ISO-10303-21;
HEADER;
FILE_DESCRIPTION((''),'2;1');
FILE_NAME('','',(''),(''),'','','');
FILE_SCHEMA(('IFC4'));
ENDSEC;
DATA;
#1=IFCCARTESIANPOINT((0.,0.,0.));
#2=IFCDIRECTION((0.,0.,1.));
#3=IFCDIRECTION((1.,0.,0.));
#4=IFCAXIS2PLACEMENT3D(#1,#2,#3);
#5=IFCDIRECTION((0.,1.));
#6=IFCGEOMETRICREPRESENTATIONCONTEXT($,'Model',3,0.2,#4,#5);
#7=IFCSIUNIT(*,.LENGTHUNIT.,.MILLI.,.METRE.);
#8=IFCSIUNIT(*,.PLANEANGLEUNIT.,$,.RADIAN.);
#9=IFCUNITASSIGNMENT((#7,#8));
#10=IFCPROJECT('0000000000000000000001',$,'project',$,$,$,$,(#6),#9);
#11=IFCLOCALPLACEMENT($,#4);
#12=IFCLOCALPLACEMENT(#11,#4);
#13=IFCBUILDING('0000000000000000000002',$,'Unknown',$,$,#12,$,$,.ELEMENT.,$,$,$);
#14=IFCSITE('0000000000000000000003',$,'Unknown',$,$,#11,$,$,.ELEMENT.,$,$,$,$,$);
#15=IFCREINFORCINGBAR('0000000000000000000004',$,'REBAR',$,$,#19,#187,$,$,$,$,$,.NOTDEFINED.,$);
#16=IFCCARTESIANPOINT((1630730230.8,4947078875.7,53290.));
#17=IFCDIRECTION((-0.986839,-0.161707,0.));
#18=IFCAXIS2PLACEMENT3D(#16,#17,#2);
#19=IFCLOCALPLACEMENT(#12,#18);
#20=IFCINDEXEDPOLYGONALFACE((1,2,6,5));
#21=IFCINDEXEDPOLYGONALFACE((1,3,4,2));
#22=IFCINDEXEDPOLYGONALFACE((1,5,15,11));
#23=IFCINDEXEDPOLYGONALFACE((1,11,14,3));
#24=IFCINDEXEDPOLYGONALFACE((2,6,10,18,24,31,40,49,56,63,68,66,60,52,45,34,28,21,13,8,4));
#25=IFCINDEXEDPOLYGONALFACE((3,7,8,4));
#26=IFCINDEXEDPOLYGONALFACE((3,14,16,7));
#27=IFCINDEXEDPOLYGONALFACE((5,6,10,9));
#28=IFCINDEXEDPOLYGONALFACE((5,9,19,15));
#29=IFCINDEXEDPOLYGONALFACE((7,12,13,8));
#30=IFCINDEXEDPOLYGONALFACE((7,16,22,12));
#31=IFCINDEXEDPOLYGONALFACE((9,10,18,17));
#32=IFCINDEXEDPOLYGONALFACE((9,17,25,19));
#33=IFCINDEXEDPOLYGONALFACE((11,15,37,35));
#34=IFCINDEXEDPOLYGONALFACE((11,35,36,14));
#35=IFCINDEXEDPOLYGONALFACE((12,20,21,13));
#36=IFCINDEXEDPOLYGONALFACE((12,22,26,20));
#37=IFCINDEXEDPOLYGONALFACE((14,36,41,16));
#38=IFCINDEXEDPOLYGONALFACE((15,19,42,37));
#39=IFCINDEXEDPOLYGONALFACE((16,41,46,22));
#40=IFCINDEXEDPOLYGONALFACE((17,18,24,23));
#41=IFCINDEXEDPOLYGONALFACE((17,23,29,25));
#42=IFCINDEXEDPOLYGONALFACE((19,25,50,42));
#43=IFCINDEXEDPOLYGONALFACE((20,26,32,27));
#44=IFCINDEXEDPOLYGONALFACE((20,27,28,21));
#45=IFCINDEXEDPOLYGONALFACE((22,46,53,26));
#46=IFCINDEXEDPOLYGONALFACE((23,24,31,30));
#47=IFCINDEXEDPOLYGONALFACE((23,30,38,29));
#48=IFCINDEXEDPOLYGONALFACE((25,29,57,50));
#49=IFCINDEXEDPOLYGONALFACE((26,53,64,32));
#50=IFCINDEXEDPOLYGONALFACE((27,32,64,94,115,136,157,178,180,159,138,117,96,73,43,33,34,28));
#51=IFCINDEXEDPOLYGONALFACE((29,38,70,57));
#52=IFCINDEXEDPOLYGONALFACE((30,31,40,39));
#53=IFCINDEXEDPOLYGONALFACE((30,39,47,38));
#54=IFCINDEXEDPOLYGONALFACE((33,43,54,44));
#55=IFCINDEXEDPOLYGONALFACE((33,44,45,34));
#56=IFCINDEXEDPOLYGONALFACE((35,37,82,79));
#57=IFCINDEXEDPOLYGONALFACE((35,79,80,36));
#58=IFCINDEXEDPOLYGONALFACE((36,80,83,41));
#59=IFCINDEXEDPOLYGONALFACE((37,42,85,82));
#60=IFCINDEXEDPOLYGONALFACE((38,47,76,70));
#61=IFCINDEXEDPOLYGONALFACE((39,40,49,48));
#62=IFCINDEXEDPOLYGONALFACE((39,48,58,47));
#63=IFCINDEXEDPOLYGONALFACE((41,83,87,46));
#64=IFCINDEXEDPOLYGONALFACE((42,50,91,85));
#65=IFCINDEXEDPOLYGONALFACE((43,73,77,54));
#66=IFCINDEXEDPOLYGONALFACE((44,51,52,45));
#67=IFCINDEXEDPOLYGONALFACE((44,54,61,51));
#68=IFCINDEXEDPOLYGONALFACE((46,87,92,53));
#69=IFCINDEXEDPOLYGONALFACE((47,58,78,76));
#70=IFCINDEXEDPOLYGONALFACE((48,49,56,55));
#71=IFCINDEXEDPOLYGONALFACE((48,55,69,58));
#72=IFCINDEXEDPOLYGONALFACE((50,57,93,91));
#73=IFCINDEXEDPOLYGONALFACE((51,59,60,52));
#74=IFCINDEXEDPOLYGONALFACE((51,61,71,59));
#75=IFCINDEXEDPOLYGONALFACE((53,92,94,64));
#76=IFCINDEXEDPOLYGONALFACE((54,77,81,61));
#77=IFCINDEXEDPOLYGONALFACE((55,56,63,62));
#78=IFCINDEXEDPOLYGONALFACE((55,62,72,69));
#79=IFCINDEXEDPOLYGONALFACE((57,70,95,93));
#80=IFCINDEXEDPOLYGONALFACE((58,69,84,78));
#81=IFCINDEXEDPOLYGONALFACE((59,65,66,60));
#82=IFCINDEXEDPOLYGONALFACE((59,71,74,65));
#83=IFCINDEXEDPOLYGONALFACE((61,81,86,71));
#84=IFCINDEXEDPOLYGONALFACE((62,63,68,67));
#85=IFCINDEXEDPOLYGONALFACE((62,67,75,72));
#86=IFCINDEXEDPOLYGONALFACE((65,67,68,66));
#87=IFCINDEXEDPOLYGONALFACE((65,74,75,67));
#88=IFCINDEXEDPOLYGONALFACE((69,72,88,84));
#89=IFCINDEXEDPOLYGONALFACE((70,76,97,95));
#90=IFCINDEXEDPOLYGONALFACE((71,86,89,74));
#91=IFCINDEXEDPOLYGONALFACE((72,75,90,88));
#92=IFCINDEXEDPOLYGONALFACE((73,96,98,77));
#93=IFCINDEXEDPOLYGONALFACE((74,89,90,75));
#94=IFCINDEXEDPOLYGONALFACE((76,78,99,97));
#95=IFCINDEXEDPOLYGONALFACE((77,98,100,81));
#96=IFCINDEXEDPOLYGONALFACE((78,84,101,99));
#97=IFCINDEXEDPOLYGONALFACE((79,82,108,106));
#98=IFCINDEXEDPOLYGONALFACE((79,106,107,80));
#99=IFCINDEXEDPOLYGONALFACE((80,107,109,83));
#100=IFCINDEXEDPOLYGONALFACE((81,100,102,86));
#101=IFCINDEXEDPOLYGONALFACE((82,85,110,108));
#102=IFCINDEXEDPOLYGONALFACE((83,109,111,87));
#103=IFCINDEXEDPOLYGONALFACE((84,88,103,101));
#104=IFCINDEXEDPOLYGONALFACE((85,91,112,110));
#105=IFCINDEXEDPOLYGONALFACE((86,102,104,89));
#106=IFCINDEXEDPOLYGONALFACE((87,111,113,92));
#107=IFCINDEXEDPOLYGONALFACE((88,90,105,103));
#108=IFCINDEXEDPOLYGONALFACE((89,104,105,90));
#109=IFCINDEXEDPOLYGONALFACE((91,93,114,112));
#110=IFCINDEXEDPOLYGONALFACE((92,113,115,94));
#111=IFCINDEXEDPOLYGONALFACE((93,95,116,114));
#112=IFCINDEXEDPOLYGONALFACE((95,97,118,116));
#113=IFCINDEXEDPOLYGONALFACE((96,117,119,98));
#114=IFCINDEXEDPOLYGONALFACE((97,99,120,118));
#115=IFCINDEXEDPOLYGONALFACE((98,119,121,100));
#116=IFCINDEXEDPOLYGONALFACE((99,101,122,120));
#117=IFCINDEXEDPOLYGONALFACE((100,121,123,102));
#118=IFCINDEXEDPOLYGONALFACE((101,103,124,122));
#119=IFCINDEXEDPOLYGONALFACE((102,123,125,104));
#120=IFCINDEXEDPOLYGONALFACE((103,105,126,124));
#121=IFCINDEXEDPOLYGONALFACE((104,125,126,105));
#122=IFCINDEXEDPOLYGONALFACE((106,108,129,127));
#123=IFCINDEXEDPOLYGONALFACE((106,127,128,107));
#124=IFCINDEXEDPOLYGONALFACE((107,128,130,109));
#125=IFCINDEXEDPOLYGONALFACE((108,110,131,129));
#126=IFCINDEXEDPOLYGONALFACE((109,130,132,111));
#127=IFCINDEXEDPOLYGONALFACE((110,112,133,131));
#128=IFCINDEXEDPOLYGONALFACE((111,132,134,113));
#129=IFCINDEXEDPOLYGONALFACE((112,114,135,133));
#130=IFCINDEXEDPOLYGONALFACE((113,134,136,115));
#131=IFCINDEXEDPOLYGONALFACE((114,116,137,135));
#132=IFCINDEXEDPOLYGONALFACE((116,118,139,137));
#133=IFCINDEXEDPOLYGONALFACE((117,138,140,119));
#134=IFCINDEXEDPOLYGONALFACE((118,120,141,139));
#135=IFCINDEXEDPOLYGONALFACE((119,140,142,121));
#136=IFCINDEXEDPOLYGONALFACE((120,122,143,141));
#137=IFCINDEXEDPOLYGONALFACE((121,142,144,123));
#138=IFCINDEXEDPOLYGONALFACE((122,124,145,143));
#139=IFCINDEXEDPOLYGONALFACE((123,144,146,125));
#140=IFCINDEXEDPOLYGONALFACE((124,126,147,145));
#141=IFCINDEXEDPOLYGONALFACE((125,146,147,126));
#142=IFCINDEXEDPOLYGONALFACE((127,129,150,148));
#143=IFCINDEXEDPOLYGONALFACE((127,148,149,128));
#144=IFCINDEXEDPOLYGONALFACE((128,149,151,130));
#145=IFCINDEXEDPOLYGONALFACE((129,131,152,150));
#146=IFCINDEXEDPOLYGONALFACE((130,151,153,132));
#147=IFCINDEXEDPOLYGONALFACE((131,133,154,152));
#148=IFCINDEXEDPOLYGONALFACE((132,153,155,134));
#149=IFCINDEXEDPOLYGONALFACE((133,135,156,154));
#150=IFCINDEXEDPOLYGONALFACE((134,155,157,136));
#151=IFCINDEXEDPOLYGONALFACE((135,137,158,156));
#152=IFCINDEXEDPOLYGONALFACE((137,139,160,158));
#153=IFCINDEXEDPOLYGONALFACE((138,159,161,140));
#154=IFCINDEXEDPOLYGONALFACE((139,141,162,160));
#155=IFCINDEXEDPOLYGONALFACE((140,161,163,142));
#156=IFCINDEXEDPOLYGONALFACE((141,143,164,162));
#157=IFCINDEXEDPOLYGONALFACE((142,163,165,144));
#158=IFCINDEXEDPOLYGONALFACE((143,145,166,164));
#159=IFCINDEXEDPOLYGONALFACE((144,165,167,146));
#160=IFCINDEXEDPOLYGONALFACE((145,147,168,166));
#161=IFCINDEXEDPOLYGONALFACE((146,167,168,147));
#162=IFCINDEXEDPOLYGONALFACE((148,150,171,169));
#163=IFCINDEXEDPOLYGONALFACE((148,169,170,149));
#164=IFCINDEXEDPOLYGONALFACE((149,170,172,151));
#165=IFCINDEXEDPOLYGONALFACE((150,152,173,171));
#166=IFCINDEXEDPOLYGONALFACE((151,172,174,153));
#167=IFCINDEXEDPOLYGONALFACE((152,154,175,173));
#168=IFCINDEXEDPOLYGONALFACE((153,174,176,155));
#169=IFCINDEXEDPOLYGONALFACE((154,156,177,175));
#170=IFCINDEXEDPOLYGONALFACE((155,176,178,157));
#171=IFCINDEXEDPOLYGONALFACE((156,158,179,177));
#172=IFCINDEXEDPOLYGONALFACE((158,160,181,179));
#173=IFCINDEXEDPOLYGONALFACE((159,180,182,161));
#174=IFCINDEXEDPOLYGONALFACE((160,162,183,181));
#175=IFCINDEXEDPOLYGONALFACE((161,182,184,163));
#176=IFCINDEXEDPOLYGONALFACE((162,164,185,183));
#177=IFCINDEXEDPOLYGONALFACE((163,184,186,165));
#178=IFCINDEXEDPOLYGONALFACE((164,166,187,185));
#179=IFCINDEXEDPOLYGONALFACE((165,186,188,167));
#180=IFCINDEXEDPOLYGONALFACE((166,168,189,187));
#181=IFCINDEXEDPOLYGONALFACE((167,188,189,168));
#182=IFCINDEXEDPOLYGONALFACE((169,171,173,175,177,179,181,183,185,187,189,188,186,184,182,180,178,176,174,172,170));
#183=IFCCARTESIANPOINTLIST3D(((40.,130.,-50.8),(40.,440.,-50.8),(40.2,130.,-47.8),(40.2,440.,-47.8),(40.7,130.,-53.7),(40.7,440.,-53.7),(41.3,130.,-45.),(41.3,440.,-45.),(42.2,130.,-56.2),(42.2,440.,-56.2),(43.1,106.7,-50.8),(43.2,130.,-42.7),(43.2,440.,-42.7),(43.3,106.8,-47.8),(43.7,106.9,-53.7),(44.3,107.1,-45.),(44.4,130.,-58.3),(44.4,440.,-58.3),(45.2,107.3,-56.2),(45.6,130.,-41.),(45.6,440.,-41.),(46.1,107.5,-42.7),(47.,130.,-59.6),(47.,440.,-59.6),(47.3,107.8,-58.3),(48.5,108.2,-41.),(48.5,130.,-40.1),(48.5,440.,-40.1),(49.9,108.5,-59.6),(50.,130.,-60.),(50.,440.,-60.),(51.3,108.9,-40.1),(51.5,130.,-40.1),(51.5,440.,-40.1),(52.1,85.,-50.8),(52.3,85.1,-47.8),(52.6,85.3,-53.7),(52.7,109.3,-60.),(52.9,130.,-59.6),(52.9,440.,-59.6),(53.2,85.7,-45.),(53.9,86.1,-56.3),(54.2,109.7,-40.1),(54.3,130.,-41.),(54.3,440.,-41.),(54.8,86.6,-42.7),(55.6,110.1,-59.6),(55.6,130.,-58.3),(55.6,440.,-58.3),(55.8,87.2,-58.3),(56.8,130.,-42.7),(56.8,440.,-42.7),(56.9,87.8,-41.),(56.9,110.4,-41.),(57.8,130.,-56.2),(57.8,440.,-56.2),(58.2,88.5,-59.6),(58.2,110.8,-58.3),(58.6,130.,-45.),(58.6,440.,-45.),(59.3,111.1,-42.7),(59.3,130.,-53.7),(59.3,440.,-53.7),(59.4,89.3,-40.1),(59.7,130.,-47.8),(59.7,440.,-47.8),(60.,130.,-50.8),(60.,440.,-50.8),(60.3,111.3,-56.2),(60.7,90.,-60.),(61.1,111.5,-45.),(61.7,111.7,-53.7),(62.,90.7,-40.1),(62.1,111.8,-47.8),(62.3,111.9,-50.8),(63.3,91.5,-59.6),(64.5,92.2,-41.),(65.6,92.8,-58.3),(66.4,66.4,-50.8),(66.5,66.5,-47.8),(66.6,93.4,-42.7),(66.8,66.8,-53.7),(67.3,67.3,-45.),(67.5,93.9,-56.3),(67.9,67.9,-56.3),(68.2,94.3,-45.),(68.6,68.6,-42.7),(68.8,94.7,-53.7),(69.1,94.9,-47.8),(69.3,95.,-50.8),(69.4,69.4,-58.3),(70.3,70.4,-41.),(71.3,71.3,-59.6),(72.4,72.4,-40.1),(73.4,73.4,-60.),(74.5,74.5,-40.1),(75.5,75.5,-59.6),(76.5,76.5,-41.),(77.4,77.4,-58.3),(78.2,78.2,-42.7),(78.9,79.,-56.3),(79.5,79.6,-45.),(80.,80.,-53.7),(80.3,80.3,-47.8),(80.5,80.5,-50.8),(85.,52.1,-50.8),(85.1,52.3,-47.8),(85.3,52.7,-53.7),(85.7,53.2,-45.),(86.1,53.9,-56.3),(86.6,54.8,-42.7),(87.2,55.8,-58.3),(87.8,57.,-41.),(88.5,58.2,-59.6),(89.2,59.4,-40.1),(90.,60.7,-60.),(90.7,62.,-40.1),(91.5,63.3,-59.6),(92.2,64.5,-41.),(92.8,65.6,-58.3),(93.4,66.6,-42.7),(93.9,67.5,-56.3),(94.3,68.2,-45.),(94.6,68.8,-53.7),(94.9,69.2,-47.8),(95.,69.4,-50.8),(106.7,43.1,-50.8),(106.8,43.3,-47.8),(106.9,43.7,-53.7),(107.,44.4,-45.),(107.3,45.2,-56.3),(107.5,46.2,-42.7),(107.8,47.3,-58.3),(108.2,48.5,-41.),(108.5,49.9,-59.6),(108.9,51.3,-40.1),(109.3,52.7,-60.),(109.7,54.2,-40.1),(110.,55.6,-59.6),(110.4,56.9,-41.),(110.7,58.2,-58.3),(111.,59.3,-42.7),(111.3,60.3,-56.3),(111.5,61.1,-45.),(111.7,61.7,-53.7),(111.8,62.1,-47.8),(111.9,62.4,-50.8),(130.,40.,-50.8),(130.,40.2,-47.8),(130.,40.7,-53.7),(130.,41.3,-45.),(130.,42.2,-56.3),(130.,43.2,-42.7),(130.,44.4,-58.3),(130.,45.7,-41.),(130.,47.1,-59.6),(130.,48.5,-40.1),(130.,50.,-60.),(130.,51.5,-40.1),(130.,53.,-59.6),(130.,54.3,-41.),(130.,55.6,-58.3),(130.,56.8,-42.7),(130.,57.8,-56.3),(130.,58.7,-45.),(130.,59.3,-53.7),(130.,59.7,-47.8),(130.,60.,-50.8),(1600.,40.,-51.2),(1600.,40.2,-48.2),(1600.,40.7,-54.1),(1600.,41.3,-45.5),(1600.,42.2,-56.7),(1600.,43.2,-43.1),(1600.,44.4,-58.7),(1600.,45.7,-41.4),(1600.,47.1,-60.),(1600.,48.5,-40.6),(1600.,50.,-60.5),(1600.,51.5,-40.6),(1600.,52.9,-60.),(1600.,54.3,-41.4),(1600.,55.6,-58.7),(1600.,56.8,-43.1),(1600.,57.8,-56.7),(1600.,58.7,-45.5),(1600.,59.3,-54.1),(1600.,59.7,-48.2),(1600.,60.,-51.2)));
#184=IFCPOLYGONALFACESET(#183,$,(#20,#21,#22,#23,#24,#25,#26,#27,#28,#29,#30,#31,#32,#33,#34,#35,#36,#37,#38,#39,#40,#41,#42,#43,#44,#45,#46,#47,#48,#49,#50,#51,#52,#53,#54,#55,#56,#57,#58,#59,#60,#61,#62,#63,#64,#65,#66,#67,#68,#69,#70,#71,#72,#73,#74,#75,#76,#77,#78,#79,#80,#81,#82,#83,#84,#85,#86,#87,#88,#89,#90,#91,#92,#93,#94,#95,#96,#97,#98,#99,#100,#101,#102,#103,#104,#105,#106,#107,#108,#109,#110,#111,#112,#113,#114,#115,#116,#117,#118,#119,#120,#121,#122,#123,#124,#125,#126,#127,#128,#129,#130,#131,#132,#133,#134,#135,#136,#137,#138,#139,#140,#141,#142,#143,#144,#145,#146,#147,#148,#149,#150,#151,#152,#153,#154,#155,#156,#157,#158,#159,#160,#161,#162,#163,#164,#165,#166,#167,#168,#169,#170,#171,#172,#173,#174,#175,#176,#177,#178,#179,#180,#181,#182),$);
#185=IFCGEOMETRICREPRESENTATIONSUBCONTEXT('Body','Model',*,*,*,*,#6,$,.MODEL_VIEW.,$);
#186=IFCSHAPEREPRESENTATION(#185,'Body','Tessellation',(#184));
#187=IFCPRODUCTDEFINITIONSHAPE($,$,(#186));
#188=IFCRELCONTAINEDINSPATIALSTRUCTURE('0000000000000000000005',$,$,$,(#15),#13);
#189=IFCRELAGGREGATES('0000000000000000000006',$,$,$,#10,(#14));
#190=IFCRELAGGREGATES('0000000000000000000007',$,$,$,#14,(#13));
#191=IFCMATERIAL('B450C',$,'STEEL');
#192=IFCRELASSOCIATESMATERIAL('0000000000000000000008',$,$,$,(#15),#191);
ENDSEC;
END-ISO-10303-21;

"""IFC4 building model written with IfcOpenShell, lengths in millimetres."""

from ifc_helpers import new_model, entity, si_unit, direction, frame, origin_with_axes, place, context, subcontext, project, spatial, material, element, save


model = new_model("IFC4")

# Units and contexts
model_context = context("Model", 3, precision=0.2, world=origin_with_axes(), true_north=direction((0.0, 1.0)))
body_context = subcontext(model_context, "Body", "Model", "MODEL_VIEW")
ifc_project = project(units=[si_unit("LENGTHUNIT", "METRE", prefix="MILLI"), si_unit("PLANEANGLEUNIT", "RADIAN")], contexts=[model_context])

# Site, building
site_placement = place(None, origin_with_axes())
site = spatial("IfcSite", under=ifc_project, at=site_placement, Name="Unknown", CompositionType="ELEMENT")
building_placement = place(site_placement, origin_with_axes())
building = spatial("IfcBuilding", under=site, at=building_placement, Name="Unknown", CompositionType="ELEMENT")

# Reinforcing bar
ifc_material = material(Name="B450C", Category="STEEL")
reinforcing_bar_1_placement = place(building_placement, frame((1630730230.8, 4947078875.7, 53290.0), z_axis=(-0.986839, -0.161707, 0.0), x_axis=(0.0, 0.0, 1.0)))
element("IfcReinforcingBar", 1, at=reinforcing_bar_1_placement, inside=building, material=ifc_material, Name="REBAR", PredefinedType="NOTDEFINED", context=body_context, shape_type="AdvancedSweptSolid", body=[
    entity("IfcSweptDiskSolid", entity("IfcIndexedPolyCurve", entity("IfcCartesianPointList3D", [[50.0, 440.0, -50.0], [50.0, 130.0, -50.0], [73.4, 73.4, -50.0], [130.0, 50.0, -50.0], [1600.0, 50.0, -50.5]]), [entity("IfcLineIndex", [1, 2]), entity("IfcArcIndex", [2, 3, 4]), entity("IfcLineIndex", [4, 5])]), 10.0),
])

save(model, "model.ifc")
